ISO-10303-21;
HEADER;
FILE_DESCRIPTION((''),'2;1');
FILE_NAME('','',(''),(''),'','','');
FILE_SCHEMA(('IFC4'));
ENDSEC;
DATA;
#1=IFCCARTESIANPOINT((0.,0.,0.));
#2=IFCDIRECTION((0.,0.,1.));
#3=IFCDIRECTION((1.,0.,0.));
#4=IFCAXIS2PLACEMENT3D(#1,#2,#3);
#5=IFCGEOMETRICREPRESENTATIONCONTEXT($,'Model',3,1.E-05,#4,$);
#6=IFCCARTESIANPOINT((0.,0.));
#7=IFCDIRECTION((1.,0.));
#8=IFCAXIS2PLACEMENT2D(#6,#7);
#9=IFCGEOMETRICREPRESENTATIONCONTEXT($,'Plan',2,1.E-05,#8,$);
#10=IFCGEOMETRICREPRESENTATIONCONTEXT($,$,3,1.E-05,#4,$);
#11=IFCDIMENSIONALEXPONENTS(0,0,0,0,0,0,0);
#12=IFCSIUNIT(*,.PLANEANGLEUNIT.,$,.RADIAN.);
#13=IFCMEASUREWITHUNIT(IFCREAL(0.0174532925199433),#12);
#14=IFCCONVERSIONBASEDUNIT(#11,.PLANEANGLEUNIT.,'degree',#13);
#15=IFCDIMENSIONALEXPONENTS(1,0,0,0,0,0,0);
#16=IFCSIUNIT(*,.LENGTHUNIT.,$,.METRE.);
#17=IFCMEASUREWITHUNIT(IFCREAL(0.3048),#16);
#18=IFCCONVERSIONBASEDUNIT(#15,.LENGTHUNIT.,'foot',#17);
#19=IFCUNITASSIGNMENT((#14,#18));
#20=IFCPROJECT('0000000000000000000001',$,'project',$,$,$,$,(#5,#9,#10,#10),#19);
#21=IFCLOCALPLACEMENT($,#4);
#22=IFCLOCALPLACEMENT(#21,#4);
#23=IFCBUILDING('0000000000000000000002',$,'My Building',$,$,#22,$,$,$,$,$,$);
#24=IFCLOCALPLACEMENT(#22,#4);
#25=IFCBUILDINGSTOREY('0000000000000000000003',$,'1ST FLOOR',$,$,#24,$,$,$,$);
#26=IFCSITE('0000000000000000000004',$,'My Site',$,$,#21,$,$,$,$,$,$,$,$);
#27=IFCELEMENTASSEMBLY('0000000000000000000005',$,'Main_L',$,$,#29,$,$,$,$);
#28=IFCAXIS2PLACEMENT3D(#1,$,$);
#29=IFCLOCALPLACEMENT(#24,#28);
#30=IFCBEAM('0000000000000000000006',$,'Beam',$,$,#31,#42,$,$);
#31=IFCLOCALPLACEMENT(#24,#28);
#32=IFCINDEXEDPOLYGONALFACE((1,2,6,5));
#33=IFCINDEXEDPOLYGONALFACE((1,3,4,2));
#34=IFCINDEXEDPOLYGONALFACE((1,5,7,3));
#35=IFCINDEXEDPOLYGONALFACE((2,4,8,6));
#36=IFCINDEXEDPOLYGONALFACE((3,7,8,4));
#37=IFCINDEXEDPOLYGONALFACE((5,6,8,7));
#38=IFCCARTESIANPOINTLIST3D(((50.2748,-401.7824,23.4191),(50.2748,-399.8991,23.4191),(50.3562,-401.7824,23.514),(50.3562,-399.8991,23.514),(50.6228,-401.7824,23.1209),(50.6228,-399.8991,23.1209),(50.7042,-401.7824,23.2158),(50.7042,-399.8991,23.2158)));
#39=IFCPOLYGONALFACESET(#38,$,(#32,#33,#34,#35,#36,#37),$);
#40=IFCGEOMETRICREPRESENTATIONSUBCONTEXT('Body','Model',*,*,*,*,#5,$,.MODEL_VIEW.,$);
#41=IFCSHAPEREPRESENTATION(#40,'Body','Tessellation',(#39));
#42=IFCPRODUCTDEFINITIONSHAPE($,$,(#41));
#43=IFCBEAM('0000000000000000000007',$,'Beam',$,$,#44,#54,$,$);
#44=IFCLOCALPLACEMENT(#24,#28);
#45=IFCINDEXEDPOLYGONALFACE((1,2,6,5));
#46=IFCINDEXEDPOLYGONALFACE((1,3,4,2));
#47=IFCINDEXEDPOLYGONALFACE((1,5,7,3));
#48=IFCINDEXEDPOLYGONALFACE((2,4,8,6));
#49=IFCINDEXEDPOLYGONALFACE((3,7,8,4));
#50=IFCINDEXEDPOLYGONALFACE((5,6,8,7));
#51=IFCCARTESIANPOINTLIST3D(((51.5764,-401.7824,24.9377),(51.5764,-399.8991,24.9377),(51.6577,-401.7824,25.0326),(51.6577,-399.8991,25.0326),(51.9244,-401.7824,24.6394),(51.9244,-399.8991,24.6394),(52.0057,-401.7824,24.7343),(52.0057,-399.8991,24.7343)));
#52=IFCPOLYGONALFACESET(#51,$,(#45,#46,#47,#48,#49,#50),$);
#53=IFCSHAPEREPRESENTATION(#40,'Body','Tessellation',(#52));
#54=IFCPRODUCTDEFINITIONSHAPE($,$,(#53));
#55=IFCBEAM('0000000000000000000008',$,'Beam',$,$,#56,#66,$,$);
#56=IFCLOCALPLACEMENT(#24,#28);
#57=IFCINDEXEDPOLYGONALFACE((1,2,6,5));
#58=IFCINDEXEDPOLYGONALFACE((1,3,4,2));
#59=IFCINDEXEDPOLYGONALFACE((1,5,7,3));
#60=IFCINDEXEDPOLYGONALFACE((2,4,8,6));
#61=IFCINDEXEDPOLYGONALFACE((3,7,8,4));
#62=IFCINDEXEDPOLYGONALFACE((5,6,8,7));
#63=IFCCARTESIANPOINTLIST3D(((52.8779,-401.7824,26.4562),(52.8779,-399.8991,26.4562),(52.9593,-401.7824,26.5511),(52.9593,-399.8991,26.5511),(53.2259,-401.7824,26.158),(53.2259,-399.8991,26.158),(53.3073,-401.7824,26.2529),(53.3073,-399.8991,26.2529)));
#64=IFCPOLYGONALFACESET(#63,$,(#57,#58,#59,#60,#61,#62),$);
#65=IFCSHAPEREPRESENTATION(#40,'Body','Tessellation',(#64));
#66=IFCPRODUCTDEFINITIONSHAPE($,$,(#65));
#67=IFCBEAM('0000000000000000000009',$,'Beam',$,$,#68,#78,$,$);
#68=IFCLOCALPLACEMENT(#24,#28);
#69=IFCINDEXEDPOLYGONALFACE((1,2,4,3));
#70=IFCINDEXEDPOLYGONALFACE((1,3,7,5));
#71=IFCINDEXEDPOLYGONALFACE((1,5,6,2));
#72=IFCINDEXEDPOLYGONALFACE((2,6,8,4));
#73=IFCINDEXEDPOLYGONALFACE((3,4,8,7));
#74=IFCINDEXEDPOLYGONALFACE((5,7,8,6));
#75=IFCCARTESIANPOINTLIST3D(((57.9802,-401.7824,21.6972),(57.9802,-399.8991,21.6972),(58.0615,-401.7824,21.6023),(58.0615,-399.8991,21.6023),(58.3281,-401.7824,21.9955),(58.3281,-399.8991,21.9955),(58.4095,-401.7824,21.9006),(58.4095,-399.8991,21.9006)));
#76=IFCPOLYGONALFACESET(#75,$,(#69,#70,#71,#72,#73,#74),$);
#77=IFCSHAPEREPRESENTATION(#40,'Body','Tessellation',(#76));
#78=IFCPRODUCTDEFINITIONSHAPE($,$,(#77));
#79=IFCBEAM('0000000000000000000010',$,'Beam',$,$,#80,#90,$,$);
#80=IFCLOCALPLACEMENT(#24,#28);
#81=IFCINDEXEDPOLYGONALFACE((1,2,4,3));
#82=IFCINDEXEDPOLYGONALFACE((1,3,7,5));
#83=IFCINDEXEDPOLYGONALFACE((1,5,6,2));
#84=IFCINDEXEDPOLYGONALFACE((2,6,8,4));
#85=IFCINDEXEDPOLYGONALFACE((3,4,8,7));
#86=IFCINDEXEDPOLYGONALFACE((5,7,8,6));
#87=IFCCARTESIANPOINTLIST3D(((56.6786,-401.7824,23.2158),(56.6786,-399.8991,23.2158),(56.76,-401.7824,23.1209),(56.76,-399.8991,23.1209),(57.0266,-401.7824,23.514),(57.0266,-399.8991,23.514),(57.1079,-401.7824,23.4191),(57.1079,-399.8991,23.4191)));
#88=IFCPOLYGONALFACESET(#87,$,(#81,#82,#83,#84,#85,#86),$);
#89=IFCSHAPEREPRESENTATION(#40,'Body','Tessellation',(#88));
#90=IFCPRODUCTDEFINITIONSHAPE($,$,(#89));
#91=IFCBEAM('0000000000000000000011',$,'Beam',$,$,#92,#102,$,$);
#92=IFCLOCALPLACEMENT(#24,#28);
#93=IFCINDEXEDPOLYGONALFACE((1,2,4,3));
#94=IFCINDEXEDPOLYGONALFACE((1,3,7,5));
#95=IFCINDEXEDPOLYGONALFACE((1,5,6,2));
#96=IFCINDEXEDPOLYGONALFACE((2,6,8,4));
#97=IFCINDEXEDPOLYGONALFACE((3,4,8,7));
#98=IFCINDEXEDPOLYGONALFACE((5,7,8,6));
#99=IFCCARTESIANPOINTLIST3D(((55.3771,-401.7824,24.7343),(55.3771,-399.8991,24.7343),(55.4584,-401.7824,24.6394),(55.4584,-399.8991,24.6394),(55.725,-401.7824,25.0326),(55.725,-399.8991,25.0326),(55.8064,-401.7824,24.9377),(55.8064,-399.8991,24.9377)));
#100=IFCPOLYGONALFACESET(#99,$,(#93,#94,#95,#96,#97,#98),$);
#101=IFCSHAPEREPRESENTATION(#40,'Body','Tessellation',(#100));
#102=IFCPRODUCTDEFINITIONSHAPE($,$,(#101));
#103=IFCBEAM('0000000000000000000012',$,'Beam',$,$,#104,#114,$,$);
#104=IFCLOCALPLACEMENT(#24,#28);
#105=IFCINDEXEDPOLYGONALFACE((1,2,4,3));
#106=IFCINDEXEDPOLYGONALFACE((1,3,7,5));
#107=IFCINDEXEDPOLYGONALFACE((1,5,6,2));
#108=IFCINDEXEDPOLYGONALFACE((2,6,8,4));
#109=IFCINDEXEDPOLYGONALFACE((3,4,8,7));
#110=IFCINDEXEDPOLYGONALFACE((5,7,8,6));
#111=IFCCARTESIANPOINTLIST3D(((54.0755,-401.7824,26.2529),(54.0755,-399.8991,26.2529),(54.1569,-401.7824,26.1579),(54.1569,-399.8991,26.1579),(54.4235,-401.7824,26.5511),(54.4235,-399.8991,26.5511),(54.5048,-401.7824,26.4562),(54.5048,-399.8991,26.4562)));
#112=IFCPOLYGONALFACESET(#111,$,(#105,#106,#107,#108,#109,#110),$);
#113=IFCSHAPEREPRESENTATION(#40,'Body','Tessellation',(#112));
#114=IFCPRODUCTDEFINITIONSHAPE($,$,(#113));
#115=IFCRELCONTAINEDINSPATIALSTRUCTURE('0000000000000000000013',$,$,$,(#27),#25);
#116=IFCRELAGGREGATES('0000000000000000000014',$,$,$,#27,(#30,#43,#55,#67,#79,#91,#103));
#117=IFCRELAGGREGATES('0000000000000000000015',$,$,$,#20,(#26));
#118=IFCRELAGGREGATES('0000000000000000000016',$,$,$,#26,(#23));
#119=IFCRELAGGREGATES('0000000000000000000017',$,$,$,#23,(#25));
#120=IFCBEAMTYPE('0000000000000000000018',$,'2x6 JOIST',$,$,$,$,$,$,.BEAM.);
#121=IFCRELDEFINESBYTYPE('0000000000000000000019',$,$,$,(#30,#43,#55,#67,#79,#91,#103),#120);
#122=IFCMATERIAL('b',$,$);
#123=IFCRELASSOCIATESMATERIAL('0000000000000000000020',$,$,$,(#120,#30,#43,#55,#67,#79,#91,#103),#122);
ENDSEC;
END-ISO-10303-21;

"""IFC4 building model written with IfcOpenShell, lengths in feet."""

from ifc_helpers import new_model, entity, si_unit, converted_unit, frame, origin_with_axes, origin_2d_with_axis, place, context, subcontext, project, spatial, rectangle, extrude, material, material_profile, profile_set, profile_usage, type_object, element, aggregate, save


model = new_model("IFC4")

# Units and contexts
model_context = context("Model", 3, precision=1e-05, world=origin_with_axes())
plan_context = context("Plan", 2, precision=1e-05, world=origin_2d_with_axis())
context_of_model = context(None, 3, precision=1e-05, world=origin_with_axes())
body_context = subcontext(model_context, "Body", "Model", "MODEL_VIEW")
ifc_project = project(units=[converted_unit("PLANEANGLEUNIT", "degree", entity("IfcReal", 0.0174532925199433), si_unit("PLANEANGLEUNIT", "RADIAN"), dimensions=[0, 0, 0, 0, 0, 0, 0]), converted_unit("LENGTHUNIT", "foot", entity("IfcReal", 0.3048), si_unit("LENGTHUNIT", "METRE"), dimensions=[1, 0, 0, 0, 0, 0, 0])], contexts=[model_context, plan_context, context_of_model, context_of_model])

# Site, building, storey
site_placement = place(None, origin_with_axes())
site = spatial("IfcSite", under=ifc_project, at=site_placement, Name="My Site")
building_placement = place(site_placement, origin_with_axes())
building = spatial("IfcBuilding", under=site, at=building_placement, Name="My Building")
storey_placement = place(building_placement, origin_with_axes())
storey = spatial("IfcBuildingStorey", under=building, at=storey_placement, Name="1ST FLOOR")

# Element assembly, beams
assembly_placement = place(storey_placement, origin_with_axes())
assembly = element("IfcElementAssembly", 1, at=assembly_placement, inside=storey, Name="Main_L")
ifc_material_1 = material(Name="b")
ifc_material_profile = material_profile(ifc_material_1, rectangle(XDim=0.125, YDim=0.4583))
ifc_profile_set = profile_set([ifc_material_profile])
beam_type = type_object("IfcBeamType", Name="2x6 JOIST", PredefinedType="BEAM", material=ifc_profile_set)
ifc_profile_usage_1 = profile_usage(ifc_profile_set, cardinal=8)
beam_1_placement = place(assembly_placement, frame((50.3155, -399.8991, 23.4666), z_axis=(0.0, -1.0, 0.0), x_axis=(0.650774, 0.0, 0.759271)))
beam_1 = element("IfcBeam", 2, at=beam_1_placement, type_object=beam_type, material=ifc_profile_usage_1, Name="Beam", context=body_context, shape_type="SweptSolid", body=[
    extrude(rectangle(XDim=0.125, YDim=0.4583), frame((0.0, -0.2291, 0.0)), (0.0, 0.0, 1.0), 1.8833),
])
ifc_profile_usage_2 = profile_usage(ifc_profile_set, cardinal=8)
beam_2_placement = place(assembly_placement, frame((51.6171, -399.8991, 24.9851), z_axis=(0.0, -1.0, 0.0), x_axis=(0.650774, 0.0, 0.759271)))
beam_2 = element("IfcBeam", 3, at=beam_2_placement, type_object=beam_type, material=ifc_profile_usage_2, Name="Beam", context=body_context, shape_type="SweptSolid", body=[
    extrude(rectangle(XDim=0.125, YDim=0.4583), frame((0.0, -0.2291, 0.0)), (0.0, 0.0, 1.0), 1.8833),
])
ifc_profile_usage_3 = profile_usage(ifc_profile_set, cardinal=8)
beam_3_placement = place(assembly_placement, frame((52.9186, -399.8991, 26.5037), z_axis=(0.0, -1.0, 0.0), x_axis=(0.650774, 0.0, 0.759271)))
beam_3 = element("IfcBeam", 4, at=beam_3_placement, type_object=beam_type, material=ifc_profile_usage_3, Name="Beam", context=body_context, shape_type="SweptSolid", body=[
    extrude(rectangle(XDim=0.125, YDim=0.4583), frame((0.0, -0.2291, 0.0)), (0.0, 0.0, 1.0), 1.8833),
])
ifc_profile_usage_4 = profile_usage(ifc_profile_set, cardinal=8)
beam_4_placement = place(assembly_placement, frame((58.3688, -399.8991, 21.948), z_axis=(0.0, -1.0, 0.0), x_axis=(0.650774, 0.0, -0.759271)))
beam_4 = element("IfcBeam", 5, at=beam_4_placement, type_object=beam_type, material=ifc_profile_usage_4, Name="Beam", context=body_context, shape_type="SweptSolid", body=[
    extrude(rectangle(XDim=0.125, YDim=0.4583), frame((0.0, -0.2291, 0.0)), (0.0, 0.0, 1.0), 1.8833),
])
ifc_profile_usage_5 = profile_usage(ifc_profile_set, cardinal=8)
beam_5_placement = place(assembly_placement, frame((57.0673, -399.8991, 23.4666), z_axis=(0.0, -1.0, 0.0), x_axis=(0.650774, 0.0, -0.759271)))
beam_5 = element("IfcBeam", 6, at=beam_5_placement, type_object=beam_type, material=ifc_profile_usage_5, Name="Beam", context=body_context, shape_type="SweptSolid", body=[
    extrude(rectangle(XDim=0.125, YDim=0.4583), frame((0.0, -0.2291, 0.0)), (0.0, 0.0, 1.0), 1.8833),
])
ifc_profile_usage_6 = profile_usage(ifc_profile_set, cardinal=8)
beam_6_placement = place(assembly_placement, frame((55.7657, -399.8991, 24.9851), z_axis=(0.0, -1.0, 0.0), x_axis=(0.650774, 0.0, -0.759271)))
beam_6 = element("IfcBeam", 7, at=beam_6_placement, type_object=beam_type, material=ifc_profile_usage_6, Name="Beam", context=body_context, shape_type="SweptSolid", body=[
    extrude(rectangle(XDim=0.125, YDim=0.4583), frame((0.0, -0.2291, 0.0)), (0.0, 0.0, 1.0), 1.8833),
])
ifc_profile_usage_7 = profile_usage(ifc_profile_set, cardinal=8)
beam_7_placement = place(assembly_placement, frame((54.4642, -399.8991, 26.5037), z_axis=(0.0, -1.0, 0.0), x_axis=(0.650774, 0.0, -0.759271)))
beam_7 = element("IfcBeam", 8, at=beam_7_placement, type_object=beam_type, material=ifc_profile_usage_7, Name="Beam", context=body_context, shape_type="SweptSolid", body=[
    extrude(rectangle(XDim=0.125, YDim=0.4583), frame((0.0, -0.2291, 0.0)), (0.0, 0.0, 1.0), 1.8833),
])
aggregate(assembly, [beam_1, beam_2, beam_3, beam_4, beam_5, beam_6, beam_7])

save(model, "model.ifc")
